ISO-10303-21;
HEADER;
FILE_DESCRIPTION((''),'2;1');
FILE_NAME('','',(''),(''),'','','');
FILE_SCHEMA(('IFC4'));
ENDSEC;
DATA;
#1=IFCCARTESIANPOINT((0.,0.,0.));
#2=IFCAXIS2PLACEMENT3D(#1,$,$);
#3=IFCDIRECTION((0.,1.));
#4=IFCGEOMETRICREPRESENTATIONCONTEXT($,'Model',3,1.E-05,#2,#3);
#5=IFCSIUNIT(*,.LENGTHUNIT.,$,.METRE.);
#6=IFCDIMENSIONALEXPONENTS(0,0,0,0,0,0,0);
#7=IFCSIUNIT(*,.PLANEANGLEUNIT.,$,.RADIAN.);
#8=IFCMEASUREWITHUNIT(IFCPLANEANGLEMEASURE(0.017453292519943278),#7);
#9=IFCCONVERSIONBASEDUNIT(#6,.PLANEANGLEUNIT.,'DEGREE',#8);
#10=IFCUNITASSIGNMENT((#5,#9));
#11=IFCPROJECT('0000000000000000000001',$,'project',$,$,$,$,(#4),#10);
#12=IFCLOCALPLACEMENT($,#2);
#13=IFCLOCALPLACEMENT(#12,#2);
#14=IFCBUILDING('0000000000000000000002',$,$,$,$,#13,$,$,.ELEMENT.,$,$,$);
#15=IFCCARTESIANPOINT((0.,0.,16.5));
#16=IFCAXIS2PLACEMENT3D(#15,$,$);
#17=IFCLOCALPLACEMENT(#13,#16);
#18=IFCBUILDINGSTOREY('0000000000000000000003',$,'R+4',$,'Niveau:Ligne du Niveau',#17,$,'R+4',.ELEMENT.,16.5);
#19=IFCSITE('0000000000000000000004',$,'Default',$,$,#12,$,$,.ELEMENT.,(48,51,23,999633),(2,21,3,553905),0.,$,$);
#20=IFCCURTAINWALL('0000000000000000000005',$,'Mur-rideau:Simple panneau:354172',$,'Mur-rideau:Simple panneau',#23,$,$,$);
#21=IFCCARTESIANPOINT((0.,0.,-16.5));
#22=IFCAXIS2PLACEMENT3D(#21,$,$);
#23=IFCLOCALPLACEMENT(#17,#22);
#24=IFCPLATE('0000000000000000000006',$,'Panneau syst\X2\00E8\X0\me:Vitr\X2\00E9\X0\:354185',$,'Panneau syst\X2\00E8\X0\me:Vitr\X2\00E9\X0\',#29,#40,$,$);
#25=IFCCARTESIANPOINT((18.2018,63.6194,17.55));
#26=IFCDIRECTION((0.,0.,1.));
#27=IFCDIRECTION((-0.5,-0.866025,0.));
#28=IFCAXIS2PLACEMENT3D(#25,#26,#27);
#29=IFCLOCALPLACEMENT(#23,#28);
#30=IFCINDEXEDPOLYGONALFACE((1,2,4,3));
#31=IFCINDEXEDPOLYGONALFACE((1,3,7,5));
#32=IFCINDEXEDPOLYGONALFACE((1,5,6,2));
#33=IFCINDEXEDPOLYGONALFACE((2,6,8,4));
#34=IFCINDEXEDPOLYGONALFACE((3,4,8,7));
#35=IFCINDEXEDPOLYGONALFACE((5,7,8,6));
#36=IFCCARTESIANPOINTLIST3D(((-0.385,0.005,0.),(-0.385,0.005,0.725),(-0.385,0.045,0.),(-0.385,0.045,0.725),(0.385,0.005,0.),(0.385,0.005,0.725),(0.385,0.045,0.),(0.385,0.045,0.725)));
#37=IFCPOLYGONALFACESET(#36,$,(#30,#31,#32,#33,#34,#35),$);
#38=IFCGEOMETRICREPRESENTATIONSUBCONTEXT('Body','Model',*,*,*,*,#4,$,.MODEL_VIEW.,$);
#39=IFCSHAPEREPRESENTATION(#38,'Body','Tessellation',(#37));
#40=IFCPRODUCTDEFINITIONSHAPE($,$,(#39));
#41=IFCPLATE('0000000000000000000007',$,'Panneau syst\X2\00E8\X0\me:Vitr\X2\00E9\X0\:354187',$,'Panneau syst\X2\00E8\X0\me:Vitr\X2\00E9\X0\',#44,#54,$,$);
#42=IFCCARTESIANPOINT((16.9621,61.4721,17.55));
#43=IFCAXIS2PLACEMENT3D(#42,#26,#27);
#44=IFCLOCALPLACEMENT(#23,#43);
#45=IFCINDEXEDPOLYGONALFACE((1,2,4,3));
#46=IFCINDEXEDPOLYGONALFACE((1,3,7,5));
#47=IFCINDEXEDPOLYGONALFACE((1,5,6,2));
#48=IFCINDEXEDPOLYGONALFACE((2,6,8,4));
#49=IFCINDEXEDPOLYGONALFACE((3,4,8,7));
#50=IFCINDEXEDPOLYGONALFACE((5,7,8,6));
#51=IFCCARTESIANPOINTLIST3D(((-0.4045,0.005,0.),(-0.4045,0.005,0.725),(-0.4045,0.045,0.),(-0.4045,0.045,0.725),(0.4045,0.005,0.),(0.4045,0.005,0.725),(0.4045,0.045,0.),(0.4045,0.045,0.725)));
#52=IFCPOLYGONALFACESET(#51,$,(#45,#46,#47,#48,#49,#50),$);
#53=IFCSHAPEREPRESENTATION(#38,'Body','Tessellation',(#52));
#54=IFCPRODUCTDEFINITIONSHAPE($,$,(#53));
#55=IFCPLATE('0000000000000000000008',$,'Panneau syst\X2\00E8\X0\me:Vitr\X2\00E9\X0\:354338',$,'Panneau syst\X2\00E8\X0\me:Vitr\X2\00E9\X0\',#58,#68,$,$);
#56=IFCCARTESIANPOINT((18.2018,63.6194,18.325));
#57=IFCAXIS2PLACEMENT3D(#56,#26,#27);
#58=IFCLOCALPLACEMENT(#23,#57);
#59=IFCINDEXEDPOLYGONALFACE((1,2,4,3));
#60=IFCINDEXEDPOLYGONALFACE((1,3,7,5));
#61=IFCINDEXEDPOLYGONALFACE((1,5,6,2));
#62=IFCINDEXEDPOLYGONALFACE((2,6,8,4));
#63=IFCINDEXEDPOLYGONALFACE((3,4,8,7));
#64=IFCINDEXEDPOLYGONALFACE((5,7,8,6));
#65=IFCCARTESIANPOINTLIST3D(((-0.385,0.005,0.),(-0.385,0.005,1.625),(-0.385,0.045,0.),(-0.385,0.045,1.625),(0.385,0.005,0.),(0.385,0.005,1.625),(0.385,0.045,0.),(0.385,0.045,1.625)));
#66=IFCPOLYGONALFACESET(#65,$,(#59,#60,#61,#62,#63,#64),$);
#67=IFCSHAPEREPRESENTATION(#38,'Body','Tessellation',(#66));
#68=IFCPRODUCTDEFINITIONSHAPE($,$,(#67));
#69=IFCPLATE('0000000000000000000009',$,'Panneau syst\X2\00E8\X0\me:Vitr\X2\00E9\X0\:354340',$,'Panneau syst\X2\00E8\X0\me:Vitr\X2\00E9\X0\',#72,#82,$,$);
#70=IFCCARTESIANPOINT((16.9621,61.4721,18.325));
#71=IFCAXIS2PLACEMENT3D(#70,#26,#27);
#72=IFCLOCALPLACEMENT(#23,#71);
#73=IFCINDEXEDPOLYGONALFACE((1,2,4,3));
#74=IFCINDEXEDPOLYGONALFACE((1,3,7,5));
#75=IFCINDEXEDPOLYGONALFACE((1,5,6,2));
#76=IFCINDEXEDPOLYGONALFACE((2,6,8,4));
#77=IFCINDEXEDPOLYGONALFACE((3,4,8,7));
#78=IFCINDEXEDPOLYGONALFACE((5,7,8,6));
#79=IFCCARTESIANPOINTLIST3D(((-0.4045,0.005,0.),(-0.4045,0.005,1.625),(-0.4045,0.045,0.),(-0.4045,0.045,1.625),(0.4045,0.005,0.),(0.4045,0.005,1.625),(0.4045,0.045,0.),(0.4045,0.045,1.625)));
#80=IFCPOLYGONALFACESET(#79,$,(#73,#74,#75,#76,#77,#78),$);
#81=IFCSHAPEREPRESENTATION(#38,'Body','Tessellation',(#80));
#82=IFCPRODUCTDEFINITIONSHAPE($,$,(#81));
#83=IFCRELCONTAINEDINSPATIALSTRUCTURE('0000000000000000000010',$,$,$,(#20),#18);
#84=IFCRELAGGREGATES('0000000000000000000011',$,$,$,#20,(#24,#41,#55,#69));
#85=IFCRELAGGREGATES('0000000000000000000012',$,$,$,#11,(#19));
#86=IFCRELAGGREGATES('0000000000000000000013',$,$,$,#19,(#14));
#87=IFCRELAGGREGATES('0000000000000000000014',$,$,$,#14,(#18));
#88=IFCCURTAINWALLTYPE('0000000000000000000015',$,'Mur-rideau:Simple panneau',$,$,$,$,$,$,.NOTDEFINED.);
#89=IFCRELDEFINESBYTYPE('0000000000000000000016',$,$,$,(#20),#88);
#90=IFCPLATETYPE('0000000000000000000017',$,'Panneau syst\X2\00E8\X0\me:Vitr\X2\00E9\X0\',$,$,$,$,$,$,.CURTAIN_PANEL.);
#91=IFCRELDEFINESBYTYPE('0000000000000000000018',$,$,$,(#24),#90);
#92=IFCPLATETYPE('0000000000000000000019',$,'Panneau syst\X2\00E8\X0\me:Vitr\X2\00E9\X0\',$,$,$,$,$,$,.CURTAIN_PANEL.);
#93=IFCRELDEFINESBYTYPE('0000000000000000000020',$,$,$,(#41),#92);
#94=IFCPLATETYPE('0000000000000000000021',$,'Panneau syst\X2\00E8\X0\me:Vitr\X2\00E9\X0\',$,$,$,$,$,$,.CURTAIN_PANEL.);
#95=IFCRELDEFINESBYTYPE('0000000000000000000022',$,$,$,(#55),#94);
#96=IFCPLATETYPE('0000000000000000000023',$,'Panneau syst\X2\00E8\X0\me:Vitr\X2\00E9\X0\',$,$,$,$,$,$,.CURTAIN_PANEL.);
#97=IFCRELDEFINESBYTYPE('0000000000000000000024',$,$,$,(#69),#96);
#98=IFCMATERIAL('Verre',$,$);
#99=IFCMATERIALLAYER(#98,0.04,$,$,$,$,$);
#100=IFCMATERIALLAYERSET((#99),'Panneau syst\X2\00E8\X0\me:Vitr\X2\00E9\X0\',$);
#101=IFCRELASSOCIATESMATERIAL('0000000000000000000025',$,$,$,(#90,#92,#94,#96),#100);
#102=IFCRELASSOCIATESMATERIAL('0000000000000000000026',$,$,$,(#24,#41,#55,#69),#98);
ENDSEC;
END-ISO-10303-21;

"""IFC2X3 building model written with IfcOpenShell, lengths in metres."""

from ifc_helpers import new_model, entity, si_unit, converted_unit, direction, frame, frame_2d, origin, place, context, subcontext, project, spatial, rectangle, extrude, source, transform, mapped, material, layer, layer_set, type_object, type_shapes, element, aggregate, save


model = new_model("IFC2X3")

# Units and contexts
model_context = context("Model", 3, precision=1e-05, world=origin(), true_north=direction((0.0, 1.0)))
body_context = subcontext(model_context, "Body", "Model", "MODEL_VIEW")
ifc_project = project(units=[si_unit("LENGTHUNIT", "METRE"), converted_unit("PLANEANGLEUNIT", "DEGREE", entity("IfcPlaneAngleMeasure", 0.017453292519943278), si_unit("PLANEANGLEUNIT", "RADIAN"), dimensions=[0, 0, 0, 0, 0, 0, 0])], contexts=[model_context])

# Site, building, storey
site_placement = place(None, origin())
site = spatial("IfcSite", under=ifc_project, at=site_placement, Name="Default", CompositionType="ELEMENT", RefLatitude=(48, 51, 23, 999633), RefLongitude=(2, 21, 3, 553905), RefElevation=0.0)
building_placement = place(site_placement, origin())
building = spatial("IfcBuilding", under=site, at=building_placement, CompositionType="ELEMENT")
storey_placement = place(building_placement, frame((0.0, 0.0, 16.5)))
storey = spatial("IfcBuildingStorey", under=building, at=storey_placement, Name="R+4", ObjectType="Niveau:Ligne du Niveau", LongName="R+4", CompositionType="ELEMENT", Elevation=16.5)

# Curtain wall, plates
curtain_wall_type = type_object("IfcCurtainWallType", Name="Mur-rideau:Simple panneau", PredefinedType="NOTDEFINED")
curtain_wall_placement = place(storey_placement, frame((0.0, 0.0, -16.5)))
curtain_wall = element("IfcCurtainWall", 1, at=curtain_wall_placement, inside=storey, type_object=curtain_wall_type, Name="Mur-rideau:Simple panneau:354172", ObjectType="Mur-rideau:Simple panneau")
ifc_material_1 = material(Name="Verre")
ifc_layer_1 = layer(ifc_material_1, 0.04)
ifc_layer_set_1 = layer_set([ifc_layer_1], Name="Panneau système:Vitré")
plate_type_1 = type_object("IfcPlateType", Name="Panneau système:Vitré", PredefinedType="CURTAIN_PANEL", material=ifc_layer_set_1)
shared_shape_1 = source(origin(), body_context, "Body", "SweptSolid", [
    extrude(rectangle(XDim=0.04, YDim=0.77, at=frame_2d((0.0, 0.0), x_axis=(1.0, 0.0))), frame((0.0, 0.025, 0.0), z_axis=(0.0, 0.0, 1.0), x_axis=(0.0, 1.0, 0.0)), (0.0, 0.0, 1.0), 0.725),
])
type_shapes(plate_type_1, [shared_shape_1])
plate_1_placement = place(curtain_wall_placement, frame((18.2018, 63.6194, 17.55), z_axis=(0.0, 0.0, 1.0), x_axis=(-0.5, -0.866025, 0.0)))
plate_1 = element("IfcPlate", 2, at=plate_1_placement, type_object=plate_type_1, material=ifc_material_1, Name="Panneau système:Vitré:354185", ObjectType="Panneau système:Vitré", context=body_context, shape_type="MappedRepresentation", body=[
    mapped(shared_shape_1, transform((0.0, 0.0, 0.0), scale=1.0)),
])
plate_type_2 = type_object("IfcPlateType", Name="Panneau système:Vitré", PredefinedType="CURTAIN_PANEL", material=ifc_layer_set_1)
shared_shape_2 = source(origin(), body_context, "Body", "SweptSolid", [
    extrude(rectangle(XDim=0.04, YDim=0.8089, at=frame_2d((0.0, 0.0), x_axis=(1.0, 0.0))), frame((0.0, 0.025, 0.0), z_axis=(0.0, 0.0, 1.0), x_axis=(0.0, 1.0, 0.0)), (0.0, 0.0, 1.0), 0.725),
])
type_shapes(plate_type_2, [shared_shape_2])
plate_2_placement = place(curtain_wall_placement, frame((16.9621, 61.4721, 17.55), z_axis=(0.0, 0.0, 1.0), x_axis=(-0.5, -0.866025, 0.0)))
plate_2 = element("IfcPlate", 3, at=plate_2_placement, type_object=plate_type_2, material=ifc_material_1, Name="Panneau système:Vitré:354187", ObjectType="Panneau système:Vitré", context=body_context, shape_type="MappedRepresentation", body=[
    mapped(shared_shape_2, transform((0.0, 0.0, 0.0), scale=1.0)),
])
plate_type_3 = type_object("IfcPlateType", Name="Panneau système:Vitré", PredefinedType="CURTAIN_PANEL", material=ifc_layer_set_1)
shared_shape_3 = source(origin(), body_context, "Body", "SweptSolid", [
    extrude(rectangle(XDim=0.04, YDim=0.77, at=frame_2d((0.0, 0.0), x_axis=(1.0, 0.0))), frame((0.0, 0.025, 0.0), z_axis=(0.0, 0.0, 1.0), x_axis=(0.0, 1.0, 0.0)), (0.0, 0.0, 1.0), 1.625),
])
type_shapes(plate_type_3, [shared_shape_3])
plate_3_placement = place(curtain_wall_placement, frame((18.2018, 63.6194, 18.325), z_axis=(0.0, 0.0, 1.0), x_axis=(-0.5, -0.866025, 0.0)))
plate_3 = element("IfcPlate", 4, at=plate_3_placement, type_object=plate_type_3, material=ifc_material_1, Name="Panneau système:Vitré:354338", ObjectType="Panneau système:Vitré", context=body_context, shape_type="MappedRepresentation", body=[
    mapped(shared_shape_3, transform((0.0, 0.0, 0.0), scale=1.0)),
])
plate_type_4 = type_object("IfcPlateType", Name="Panneau système:Vitré", PredefinedType="CURTAIN_PANEL", material=ifc_layer_set_1)
shared_shape_4 = source(origin(), body_context, "Body", "SweptSolid", [
    extrude(rectangle(XDim=0.04, YDim=0.8089, at=frame_2d((0.0, 0.0), x_axis=(1.0, 0.0))), frame((0.0, 0.025, 0.0), z_axis=(0.0, 0.0, 1.0), x_axis=(0.0, 1.0, 0.0)), (0.0, 0.0, 1.0), 1.625),
])
type_shapes(plate_type_4, [shared_shape_4])
plate_4_placement = place(curtain_wall_placement, frame((16.9621, 61.4721, 18.325), z_axis=(0.0, 0.0, 1.0), x_axis=(-0.5, -0.866025, 0.0)))
plate_4 = element("IfcPlate", 5, at=plate_4_placement, type_object=plate_type_4, material=ifc_material_1, Name="Panneau système:Vitré:354340", ObjectType="Panneau système:Vitré", context=body_context, shape_type="MappedRepresentation", body=[
    mapped(shared_shape_4, transform((0.0, 0.0, 0.0), scale=1.0)),
])
aggregate(curtain_wall, [plate_1, plate_2, plate_3, plate_4])

save(model, "model.ifc")
